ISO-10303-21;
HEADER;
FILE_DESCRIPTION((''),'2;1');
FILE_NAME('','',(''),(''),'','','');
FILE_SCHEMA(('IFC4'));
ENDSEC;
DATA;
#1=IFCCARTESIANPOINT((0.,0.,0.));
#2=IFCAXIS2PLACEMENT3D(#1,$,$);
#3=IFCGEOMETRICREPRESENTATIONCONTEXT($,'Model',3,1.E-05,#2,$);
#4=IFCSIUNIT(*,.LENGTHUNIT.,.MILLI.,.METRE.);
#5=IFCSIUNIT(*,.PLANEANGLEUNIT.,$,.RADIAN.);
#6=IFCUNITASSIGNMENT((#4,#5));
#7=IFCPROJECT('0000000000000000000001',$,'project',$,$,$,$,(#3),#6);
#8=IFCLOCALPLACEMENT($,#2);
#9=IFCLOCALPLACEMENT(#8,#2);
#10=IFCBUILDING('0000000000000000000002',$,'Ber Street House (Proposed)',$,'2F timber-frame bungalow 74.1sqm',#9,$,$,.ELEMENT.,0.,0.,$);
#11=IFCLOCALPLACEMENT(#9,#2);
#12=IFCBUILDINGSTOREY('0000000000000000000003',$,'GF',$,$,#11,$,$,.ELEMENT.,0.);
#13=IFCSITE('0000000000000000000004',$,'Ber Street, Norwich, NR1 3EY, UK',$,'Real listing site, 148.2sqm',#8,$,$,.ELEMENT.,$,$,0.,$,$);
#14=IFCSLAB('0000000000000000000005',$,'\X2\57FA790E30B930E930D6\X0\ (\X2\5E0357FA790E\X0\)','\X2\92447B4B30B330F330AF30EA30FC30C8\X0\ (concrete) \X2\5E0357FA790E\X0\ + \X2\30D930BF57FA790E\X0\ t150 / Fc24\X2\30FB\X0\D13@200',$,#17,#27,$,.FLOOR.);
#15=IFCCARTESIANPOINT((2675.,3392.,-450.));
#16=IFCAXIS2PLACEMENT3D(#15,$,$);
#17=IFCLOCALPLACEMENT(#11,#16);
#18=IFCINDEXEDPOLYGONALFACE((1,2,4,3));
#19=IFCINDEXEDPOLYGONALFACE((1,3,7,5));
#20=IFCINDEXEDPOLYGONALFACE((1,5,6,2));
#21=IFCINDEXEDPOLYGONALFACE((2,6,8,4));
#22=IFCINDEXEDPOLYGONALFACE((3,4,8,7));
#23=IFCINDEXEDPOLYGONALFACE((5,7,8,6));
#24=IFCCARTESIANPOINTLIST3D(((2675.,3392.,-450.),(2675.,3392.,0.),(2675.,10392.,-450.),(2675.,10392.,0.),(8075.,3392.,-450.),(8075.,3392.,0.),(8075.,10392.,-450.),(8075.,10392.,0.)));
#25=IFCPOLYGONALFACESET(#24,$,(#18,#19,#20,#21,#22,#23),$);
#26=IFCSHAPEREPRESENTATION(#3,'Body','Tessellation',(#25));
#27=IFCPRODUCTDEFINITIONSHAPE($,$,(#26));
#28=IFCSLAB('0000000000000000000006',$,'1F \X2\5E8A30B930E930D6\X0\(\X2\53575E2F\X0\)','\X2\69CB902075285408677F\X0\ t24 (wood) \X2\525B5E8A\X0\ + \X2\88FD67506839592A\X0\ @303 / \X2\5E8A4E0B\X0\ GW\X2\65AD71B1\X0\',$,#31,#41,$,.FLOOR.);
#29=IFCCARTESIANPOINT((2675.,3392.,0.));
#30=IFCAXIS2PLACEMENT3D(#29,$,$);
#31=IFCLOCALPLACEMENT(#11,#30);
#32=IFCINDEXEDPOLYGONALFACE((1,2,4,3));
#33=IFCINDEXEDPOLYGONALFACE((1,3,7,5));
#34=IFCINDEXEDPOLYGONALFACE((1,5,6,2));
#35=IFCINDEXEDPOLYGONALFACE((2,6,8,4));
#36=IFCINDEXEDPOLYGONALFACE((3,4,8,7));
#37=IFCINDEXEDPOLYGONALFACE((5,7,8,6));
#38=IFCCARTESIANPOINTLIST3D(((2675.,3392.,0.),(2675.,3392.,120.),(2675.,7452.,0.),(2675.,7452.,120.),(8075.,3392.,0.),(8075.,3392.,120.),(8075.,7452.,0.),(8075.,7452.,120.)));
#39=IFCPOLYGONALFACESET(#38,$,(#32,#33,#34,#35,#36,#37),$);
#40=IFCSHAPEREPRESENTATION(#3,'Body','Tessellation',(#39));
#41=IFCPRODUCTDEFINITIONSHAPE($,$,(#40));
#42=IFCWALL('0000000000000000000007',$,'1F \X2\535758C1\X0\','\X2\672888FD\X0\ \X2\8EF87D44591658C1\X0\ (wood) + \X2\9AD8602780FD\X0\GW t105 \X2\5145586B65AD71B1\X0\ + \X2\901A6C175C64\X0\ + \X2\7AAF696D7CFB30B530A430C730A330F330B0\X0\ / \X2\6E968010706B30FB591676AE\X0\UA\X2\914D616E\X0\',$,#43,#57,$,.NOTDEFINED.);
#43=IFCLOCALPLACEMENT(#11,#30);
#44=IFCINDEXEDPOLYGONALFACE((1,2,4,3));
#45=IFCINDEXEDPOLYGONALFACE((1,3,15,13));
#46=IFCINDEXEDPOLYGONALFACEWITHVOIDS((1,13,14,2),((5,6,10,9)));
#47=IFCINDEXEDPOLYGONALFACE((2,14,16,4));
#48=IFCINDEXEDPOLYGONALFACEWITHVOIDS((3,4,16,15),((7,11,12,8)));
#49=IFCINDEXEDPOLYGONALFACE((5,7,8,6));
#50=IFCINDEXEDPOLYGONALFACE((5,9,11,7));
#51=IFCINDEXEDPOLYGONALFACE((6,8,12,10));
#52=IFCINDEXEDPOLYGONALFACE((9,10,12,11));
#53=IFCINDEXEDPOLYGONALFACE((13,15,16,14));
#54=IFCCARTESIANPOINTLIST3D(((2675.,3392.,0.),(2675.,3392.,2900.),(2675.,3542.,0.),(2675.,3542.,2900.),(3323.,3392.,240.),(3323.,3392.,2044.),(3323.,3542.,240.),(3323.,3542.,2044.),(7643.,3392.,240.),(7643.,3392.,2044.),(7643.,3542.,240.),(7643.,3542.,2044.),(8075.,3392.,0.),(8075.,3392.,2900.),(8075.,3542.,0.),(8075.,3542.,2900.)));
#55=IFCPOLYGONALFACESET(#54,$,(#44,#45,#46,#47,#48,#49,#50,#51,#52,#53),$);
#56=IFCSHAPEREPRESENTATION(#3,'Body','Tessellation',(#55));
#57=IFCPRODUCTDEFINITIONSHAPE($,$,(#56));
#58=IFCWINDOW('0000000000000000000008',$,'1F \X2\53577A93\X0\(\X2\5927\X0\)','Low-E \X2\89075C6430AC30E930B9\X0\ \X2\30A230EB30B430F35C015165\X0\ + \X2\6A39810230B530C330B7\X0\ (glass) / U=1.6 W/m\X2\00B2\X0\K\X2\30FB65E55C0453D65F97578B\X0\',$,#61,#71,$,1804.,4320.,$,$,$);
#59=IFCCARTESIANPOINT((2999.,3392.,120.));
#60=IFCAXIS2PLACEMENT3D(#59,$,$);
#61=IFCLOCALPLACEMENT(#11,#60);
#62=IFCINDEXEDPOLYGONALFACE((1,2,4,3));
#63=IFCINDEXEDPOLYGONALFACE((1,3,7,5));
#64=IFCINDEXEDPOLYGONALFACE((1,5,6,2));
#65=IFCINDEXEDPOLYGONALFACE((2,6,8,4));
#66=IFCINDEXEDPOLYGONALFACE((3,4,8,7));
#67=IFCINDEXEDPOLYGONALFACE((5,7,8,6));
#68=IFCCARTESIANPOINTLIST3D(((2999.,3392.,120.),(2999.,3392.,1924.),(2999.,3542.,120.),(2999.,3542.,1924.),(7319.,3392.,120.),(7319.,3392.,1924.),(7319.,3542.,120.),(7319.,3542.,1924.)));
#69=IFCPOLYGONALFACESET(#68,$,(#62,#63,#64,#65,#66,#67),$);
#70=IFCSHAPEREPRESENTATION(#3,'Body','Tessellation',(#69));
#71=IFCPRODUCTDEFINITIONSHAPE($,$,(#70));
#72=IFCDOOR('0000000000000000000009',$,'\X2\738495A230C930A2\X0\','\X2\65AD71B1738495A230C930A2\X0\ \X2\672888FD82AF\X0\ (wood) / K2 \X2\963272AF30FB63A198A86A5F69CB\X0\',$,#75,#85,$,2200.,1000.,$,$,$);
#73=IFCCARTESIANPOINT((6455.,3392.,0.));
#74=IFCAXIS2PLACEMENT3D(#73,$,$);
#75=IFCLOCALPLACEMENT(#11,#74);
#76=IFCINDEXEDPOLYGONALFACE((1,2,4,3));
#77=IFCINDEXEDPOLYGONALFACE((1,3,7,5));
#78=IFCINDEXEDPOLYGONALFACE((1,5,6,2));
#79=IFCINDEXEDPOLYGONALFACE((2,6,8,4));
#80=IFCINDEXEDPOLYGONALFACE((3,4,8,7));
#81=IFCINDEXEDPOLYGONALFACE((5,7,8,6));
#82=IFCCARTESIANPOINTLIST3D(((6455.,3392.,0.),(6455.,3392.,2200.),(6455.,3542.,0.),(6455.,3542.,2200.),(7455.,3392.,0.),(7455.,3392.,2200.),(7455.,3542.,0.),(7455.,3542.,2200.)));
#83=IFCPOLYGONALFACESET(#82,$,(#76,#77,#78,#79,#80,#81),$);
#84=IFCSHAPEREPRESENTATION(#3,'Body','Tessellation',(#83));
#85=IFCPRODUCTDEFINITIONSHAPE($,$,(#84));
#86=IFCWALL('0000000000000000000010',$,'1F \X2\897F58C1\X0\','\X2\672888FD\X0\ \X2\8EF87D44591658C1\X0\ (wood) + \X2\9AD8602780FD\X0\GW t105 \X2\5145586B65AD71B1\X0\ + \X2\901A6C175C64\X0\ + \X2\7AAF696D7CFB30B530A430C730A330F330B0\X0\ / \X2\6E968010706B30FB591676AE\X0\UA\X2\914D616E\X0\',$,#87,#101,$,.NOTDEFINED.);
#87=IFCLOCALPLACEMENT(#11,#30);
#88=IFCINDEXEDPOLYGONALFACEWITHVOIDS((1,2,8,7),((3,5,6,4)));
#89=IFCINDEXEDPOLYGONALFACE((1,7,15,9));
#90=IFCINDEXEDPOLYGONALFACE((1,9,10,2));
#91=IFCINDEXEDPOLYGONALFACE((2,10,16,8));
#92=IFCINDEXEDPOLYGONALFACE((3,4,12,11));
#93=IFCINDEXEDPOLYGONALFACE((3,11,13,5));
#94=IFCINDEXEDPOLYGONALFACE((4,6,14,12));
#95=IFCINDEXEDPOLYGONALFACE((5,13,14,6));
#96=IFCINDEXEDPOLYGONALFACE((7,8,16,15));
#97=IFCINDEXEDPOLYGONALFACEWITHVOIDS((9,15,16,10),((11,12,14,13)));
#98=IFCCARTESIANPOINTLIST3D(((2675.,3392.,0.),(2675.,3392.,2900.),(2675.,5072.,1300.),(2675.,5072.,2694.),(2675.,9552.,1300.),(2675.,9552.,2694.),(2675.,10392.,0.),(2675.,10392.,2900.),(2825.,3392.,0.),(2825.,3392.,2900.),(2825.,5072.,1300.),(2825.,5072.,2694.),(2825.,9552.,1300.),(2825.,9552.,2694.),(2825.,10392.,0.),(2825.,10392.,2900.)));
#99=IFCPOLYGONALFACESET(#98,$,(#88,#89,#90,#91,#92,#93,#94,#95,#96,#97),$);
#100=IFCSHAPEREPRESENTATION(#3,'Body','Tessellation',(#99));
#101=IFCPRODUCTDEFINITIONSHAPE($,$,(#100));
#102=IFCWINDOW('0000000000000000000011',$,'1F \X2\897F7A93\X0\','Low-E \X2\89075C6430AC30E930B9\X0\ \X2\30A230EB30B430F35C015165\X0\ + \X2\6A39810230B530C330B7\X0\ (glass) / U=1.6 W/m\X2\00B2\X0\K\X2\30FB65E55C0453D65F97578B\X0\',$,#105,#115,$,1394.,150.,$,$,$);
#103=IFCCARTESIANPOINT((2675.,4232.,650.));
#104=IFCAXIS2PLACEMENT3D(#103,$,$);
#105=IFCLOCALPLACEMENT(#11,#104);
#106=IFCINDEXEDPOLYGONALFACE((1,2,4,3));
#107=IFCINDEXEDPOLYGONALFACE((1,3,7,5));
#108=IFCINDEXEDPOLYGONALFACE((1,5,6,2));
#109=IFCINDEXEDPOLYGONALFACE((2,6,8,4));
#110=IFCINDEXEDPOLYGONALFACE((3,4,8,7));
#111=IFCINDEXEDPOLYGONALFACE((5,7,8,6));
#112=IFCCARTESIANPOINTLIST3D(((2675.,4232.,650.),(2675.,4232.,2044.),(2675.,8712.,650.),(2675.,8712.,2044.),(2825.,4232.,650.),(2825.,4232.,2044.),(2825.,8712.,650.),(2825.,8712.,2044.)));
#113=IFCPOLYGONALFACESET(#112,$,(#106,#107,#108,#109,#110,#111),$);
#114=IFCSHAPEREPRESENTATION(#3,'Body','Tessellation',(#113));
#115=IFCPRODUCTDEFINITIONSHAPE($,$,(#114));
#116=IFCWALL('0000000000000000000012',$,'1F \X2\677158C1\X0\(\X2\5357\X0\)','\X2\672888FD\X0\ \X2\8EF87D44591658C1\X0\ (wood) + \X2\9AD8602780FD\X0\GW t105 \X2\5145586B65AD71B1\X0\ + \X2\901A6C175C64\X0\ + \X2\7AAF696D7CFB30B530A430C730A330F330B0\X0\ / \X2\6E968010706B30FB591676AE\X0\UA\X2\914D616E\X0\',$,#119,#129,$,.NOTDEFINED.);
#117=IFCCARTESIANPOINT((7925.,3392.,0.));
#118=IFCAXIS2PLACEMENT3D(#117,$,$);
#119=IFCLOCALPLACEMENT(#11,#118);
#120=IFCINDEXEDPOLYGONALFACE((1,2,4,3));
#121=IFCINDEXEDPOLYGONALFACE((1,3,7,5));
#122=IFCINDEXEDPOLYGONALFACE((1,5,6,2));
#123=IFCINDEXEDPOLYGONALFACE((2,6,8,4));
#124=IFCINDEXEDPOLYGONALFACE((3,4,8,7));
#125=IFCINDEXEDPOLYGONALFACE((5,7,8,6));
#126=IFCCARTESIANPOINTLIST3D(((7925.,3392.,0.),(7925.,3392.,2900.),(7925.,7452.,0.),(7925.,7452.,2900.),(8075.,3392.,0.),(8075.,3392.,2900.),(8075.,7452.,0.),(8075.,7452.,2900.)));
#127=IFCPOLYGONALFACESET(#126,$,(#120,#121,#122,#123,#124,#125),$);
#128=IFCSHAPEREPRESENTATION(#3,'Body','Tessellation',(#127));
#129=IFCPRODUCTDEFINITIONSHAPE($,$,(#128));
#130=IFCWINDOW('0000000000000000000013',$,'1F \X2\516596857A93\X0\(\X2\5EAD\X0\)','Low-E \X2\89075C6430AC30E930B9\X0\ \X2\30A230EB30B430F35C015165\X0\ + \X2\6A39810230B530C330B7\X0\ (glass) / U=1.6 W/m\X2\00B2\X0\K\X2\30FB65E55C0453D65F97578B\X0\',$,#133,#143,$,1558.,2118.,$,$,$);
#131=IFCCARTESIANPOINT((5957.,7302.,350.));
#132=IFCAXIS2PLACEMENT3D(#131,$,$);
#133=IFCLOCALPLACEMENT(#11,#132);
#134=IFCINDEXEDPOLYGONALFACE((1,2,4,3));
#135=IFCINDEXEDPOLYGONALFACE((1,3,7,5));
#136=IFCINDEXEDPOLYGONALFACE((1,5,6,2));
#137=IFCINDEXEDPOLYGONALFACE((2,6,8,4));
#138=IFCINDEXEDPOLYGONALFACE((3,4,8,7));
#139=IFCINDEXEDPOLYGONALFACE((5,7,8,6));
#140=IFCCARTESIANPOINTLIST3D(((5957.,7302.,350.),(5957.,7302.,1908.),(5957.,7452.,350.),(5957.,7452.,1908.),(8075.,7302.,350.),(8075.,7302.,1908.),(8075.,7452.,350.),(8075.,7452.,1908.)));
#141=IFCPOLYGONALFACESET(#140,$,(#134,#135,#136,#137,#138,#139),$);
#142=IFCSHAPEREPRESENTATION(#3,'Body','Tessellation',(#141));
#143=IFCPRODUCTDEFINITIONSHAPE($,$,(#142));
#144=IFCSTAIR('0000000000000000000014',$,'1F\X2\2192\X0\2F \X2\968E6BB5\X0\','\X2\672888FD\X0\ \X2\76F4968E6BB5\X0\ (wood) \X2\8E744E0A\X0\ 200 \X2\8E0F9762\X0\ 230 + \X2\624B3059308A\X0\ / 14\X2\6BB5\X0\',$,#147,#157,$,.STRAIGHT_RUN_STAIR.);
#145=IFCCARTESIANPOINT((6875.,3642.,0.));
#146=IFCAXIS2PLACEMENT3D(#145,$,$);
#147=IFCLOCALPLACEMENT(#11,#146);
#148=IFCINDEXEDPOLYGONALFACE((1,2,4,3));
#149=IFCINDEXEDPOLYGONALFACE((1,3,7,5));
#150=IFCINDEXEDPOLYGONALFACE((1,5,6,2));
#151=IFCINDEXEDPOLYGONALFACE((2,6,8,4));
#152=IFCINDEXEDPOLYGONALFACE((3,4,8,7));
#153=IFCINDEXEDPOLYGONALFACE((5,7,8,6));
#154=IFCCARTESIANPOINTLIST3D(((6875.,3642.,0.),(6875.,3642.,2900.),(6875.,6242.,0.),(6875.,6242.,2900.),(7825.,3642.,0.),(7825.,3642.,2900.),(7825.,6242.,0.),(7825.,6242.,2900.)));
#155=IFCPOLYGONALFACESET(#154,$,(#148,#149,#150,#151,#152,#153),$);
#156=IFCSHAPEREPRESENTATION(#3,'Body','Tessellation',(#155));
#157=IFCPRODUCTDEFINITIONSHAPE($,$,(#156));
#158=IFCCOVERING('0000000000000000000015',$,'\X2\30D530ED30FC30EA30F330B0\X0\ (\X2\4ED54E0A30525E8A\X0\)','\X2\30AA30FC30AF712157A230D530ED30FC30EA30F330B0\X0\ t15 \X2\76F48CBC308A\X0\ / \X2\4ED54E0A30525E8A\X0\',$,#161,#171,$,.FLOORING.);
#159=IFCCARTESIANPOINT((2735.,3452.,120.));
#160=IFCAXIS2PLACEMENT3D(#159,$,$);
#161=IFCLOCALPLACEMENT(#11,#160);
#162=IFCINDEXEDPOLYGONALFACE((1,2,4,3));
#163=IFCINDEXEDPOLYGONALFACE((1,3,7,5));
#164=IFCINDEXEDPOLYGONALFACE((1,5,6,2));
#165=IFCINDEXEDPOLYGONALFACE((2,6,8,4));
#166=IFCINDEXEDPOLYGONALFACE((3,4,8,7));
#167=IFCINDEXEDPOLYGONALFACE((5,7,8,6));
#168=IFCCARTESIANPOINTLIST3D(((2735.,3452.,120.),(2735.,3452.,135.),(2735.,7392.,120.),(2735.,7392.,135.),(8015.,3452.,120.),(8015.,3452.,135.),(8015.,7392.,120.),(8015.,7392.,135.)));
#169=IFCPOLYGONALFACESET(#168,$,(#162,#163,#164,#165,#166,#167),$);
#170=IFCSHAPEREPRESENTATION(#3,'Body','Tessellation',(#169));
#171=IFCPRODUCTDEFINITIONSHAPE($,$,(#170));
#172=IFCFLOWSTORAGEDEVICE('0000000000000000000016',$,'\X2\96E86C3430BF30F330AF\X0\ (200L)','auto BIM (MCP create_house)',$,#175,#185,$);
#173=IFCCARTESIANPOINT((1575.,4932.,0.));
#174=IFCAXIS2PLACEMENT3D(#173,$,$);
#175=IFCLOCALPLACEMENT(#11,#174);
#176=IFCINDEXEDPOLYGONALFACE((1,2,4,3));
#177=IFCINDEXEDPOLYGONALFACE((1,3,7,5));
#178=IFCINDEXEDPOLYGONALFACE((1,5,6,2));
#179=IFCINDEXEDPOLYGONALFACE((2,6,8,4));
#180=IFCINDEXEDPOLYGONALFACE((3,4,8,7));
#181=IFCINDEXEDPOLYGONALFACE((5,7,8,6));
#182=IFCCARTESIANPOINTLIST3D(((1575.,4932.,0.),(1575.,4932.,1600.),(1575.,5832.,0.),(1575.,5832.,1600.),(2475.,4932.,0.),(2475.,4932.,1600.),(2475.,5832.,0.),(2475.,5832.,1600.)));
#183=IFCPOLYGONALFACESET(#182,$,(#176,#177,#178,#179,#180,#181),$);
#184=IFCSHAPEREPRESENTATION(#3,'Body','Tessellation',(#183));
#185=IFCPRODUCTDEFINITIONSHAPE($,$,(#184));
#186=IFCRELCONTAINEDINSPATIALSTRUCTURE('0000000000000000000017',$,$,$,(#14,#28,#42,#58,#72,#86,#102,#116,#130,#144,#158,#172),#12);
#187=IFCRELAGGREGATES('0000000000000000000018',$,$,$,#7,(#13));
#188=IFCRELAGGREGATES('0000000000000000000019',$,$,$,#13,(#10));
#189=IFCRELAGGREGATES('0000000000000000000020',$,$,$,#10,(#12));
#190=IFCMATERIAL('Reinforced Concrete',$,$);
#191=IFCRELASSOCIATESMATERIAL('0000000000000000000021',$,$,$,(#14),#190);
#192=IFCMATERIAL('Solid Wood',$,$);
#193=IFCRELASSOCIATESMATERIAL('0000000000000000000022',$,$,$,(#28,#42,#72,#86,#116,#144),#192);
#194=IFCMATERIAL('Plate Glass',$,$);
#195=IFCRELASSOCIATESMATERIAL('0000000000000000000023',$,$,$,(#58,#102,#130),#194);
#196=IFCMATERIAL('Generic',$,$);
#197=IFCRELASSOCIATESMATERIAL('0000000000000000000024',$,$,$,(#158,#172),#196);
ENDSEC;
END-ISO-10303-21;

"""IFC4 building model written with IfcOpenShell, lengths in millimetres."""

from ifc_helpers import new_model, si_unit, frame, frame_2d, origin, place, context, project, spatial, rectangle, extrude, material, element, fill, save


model = new_model("IFC4")

# Units and contexts
model_context = context("Model", 3, precision=1e-05, world=origin())
ifc_project = project(units=[si_unit("LENGTHUNIT", "METRE", prefix="MILLI"), si_unit("PLANEANGLEUNIT", "RADIAN")], contexts=[model_context])

# Site, building, storey
site_placement = place(None, origin())
site = spatial("IfcSite", under=ifc_project, at=site_placement, Name="Ber Street, Norwich, NR1 3EY, UK", ObjectType="Real listing site, 148.2sqm", CompositionType="ELEMENT", RefElevation=0.0)
building_placement = place(site_placement, origin())
building = spatial("IfcBuilding", under=site, at=building_placement, Name="Ber Street House (Proposed)", ObjectType="2F timber-frame bungalow 74.1sqm", CompositionType="ELEMENT", ElevationOfRefHeight=0.0, ElevationOfTerrain=0.0)
storey_placement = place(building_placement, origin())
storey = spatial("IfcBuildingStorey", under=building, at=storey_placement, Name="GF", CompositionType="ELEMENT", Elevation=0.0)

# Slabs
ifc_material_1 = material(Name="Reinforced Concrete")
slab_1_placement = place(storey_placement, frame((2675.0, 3392.0, -450.0)))
element("IfcSlab", 1, at=slab_1_placement, inside=storey, material=ifc_material_1, Name="基礎スラブ (布基礎)", Description="鉄筋コンクリート (concrete) 布基礎 + ベタ基礎 t150 / Fc24・D13@200", PredefinedType="FLOOR", context=model_context, shape_type="SweptSolid", body=[
    extrude(rectangle(XDim=5400.0, YDim=7000.0, at=frame_2d((2700.0, 3500.0))), frame((2675.0, 3392.0, -450.0)), (0.0, 0.0, 1.0), 450.0),
])
ifc_material_2 = material(Name="Solid Wood")
slab_2_placement = place(storey_placement, frame((2675.0, 3392.0, 0.0)))
element("IfcSlab", 2, at=slab_2_placement, inside=storey, material=ifc_material_2, Name="1F 床スラブ(南帯)", Description="構造用合板 t24 (wood) 剛床 + 製材根太 @303 / 床下 GW断熱", PredefinedType="FLOOR", context=model_context, shape_type="SweptSolid", body=[
    extrude(rectangle(XDim=5400.0, YDim=4060.0, at=frame_2d((2700.0, 2030.0))), frame((2675.0, 3392.0, 0.0)), (0.0, 0.0, 1.0), 120.0),
])

# Wall, openings, window, door
wall_1_placement = place(storey_placement, frame((2675.0, 3392.0, 0.0)))
wall_1 = element("IfcWall", 3, at=wall_1_placement, inside=storey, material=ifc_material_2, Name="1F 南壁", Description="木製 軸組外壁 (wood) + 高性能GW t105 充填断熱 + 通気層 + 窯業系サイディング / 準耐火・外皮UA配慮", PredefinedType="NOTDEFINED", context=model_context, shape_type="SweptSolid", body=[
    extrude(rectangle(XDim=5400.0, YDim=150.0, at=frame_2d((2700.0, 75.0))), frame((2675.0, 3392.0, 0.0)), (0.0, 0.0, 1.0), 2900.0),
])
opening_1_placement = place(storey_placement, frame((2999.0, 3392.0, 120.0)))
opening_1 = element("IfcOpeningElement", 4, at=opening_1_placement, cuts=wall_1, PredefinedType="NOTDEFINED", context=model_context, shape_type="SweptSolid", body=[
    extrude(rectangle(XDim=4320.0, YDim=150.0, at=frame_2d((2160.0, 75.0))), frame((2999.0, 3392.0, 120.0)), (0.0, 0.0, 1.0), 1804.0),
])
opening_2_placement = place(storey_placement, frame((6455.0, 3392.0, 0.0)))
opening_2 = element("IfcOpeningElement", 5, at=opening_2_placement, cuts=wall_1, PredefinedType="NOTDEFINED", context=model_context, shape_type="SweptSolid", body=[
    extrude(rectangle(XDim=1000.0, YDim=150.0, at=frame_2d((500.0, 75.0))), frame((6455.0, 3392.0, 0.0)), (0.0, 0.0, 1.0), 2200.0),
])
ifc_material_3 = material(Name="Plate Glass")
window_1_placement = place(storey_placement, frame((2999.0, 3392.0, 120.0)))
window_1 = element("IfcWindow", 6, at=window_1_placement, inside=storey, material=ifc_material_3, Name="1F 南窓(大)", Description="Low-E 複層ガラス アルゴン封入 + 樹脂サッシ (glass) / U=1.6 W/m²K・日射取得型", OverallHeight=1804.0, OverallWidth=4320.0, context=model_context, shape_type="SweptSolid", body=[
    extrude(rectangle(XDim=4320.0, YDim=150.0, at=frame_2d((2160.0, 75.0))), frame((2999.0, 3392.0, 120.0)), (0.0, 0.0, 1.0), 1804.0),
])
fill(opening_1, window_1)
door_1_placement = place(storey_placement, frame((6455.0, 3392.0, 0.0)))
door_1 = element("IfcDoor", 7, at=door_1_placement, inside=storey, material=ifc_material_2, Name="玄関ドア", Description="断熱玄関ドア 木製芯 (wood) / K2 防犯・採風機構", OverallHeight=2200.0, OverallWidth=1000.0, context=model_context, shape_type="SweptSolid", body=[
    extrude(rectangle(XDim=1000.0, YDim=150.0, at=frame_2d((500.0, 75.0))), frame((6455.0, 3392.0, 0.0)), (0.0, 0.0, 1.0), 2200.0),
])
fill(opening_2, door_1)

# Walls, openings, windows
wall_2_placement = place(storey_placement, frame((2675.0, 3392.0, 0.0)))
wall_2 = element("IfcWall", 8, at=wall_2_placement, inside=storey, material=ifc_material_2, Name="1F 西壁", Description="木製 軸組外壁 (wood) + 高性能GW t105 充填断熱 + 通気層 + 窯業系サイディング / 準耐火・外皮UA配慮", PredefinedType="NOTDEFINED", context=model_context, shape_type="SweptSolid", body=[
    extrude(rectangle(XDim=150.0, YDim=7000.0, at=frame_2d((75.0, 3500.0))), frame((2675.0, 3392.0, 0.0)), (0.0, 0.0, 1.0), 2900.0),
])
opening_3_placement = place(storey_placement, frame((2675.0, 4232.0, 650.0)))
opening_3 = element("IfcOpeningElement", 9, at=opening_3_placement, cuts=wall_2, PredefinedType="NOTDEFINED", context=model_context, shape_type="SweptSolid", body=[
    extrude(rectangle(XDim=150.0, YDim=4480.0, at=frame_2d((75.0, 2240.0))), frame((2675.0, 4232.0, 650.0)), (0.0, 0.0, 1.0), 1394.0),
])
window_2_placement = place(storey_placement, frame((2675.0, 4232.0, 650.0)))
window_2 = element("IfcWindow", 10, at=window_2_placement, inside=storey, material=ifc_material_3, Name="1F 西窓", Description="Low-E 複層ガラス アルゴン封入 + 樹脂サッシ (glass) / U=1.6 W/m²K・日射取得型", OverallHeight=1394.0, OverallWidth=150.0, context=model_context, shape_type="SweptSolid", body=[
    extrude(rectangle(XDim=150.0, YDim=4480.0, at=frame_2d((75.0, 2240.0))), frame((2675.0, 4232.0, 650.0)), (0.0, 0.0, 1.0), 1394.0),
])
fill(opening_3, window_2)
wall_3_placement = place(storey_placement, frame((7925.0, 3392.0, 0.0)))
wall_3 = element("IfcWall", 11, at=wall_3_placement, inside=storey, material=ifc_material_2, Name="1F 東壁(南)", Description="木製 軸組外壁 (wood) + 高性能GW t105 充填断熱 + 通気層 + 窯業系サイディング / 準耐火・外皮UA配慮", PredefinedType="NOTDEFINED", context=model_context, shape_type="SweptSolid", body=[
    extrude(rectangle(XDim=150.0, YDim=4060.0, at=frame_2d((75.0, 2030.0))), frame((7925.0, 3392.0, 0.0)), (0.0, 0.0, 1.0), 2900.0),
])
opening_4_placement = place(storey_placement, frame((5957.0, 7302.0, 350.0)))
opening_4 = element("IfcOpeningElement", 12, at=opening_4_placement, cuts=wall_3, PredefinedType="NOTDEFINED", context=model_context, shape_type="SweptSolid", body=[
    extrude(rectangle(XDim=2118.0, YDim=150.0, at=frame_2d((1059.0, 75.0))), frame((5957.0, 7302.0, 350.0)), (0.0, 0.0, 1.0), 1558.0),
])
window_3_placement = place(storey_placement, frame((5957.0, 7302.0, 350.0)))
window_3 = element("IfcWindow", 13, at=window_3_placement, inside=storey, material=ifc_material_3, Name="1F 入隅窓(庭)", Description="Low-E 複層ガラス アルゴン封入 + 樹脂サッシ (glass) / U=1.6 W/m²K・日射取得型", OverallHeight=1558.0, OverallWidth=2118.0, context=model_context, shape_type="SweptSolid", body=[
    extrude(rectangle(XDim=2118.0, YDim=150.0, at=frame_2d((1059.0, 75.0))), frame((5957.0, 7302.0, 350.0)), (0.0, 0.0, 1.0), 1558.0),
])
fill(opening_4, window_3)

# Stair
stair_placement = place(storey_placement, frame((6875.0, 3642.0, 0.0)))
element("IfcStair", 14, at=stair_placement, inside=storey, material=ifc_material_2, Name="1F→2F 階段", Description="木製 直階段 (wood) 蹴上 200 踏面 230 + 手すり / 14段", PredefinedType="STRAIGHT_RUN_STAIR", context=model_context, shape_type="SweptSolid", body=[
    extrude(rectangle(XDim=950.0, YDim=2600.0, at=frame_2d((475.0, 1300.0))), frame((6875.0, 3642.0, 0.0)), (0.0, 0.0, 1.0), 2900.0),
])

# Covering
ifc_material_4 = material(Name="Generic")
covering_placement = place(storey_placement, frame((2735.0, 3452.0, 120.0)))
element("IfcCovering", 15, at=covering_placement, inside=storey, material=ifc_material_4, Name="フローリング (仕上げ床)", Description="オーク無垢フローリング t15 直貼り / 仕上げ床", PredefinedType="FLOORING", context=model_context, shape_type="SweptSolid", body=[
    extrude(rectangle(XDim=5280.0, YDim=3940.0, at=frame_2d((2640.0, 1970.0))), frame((2735.0, 3452.0, 120.0)), (0.0, 0.0, 1.0), 15.0),
])

# Flow storage device
flow_storage_device_placement = place(storey_placement, frame((1575.0, 4932.0, 0.0)))
element("IfcFlowStorageDevice", 16, at=flow_storage_device_placement, inside=storey, material=ifc_material_4, Name="雨水タンク (200L)", Description="auto BIM (MCP create_house)", context=model_context, shape_type="SweptSolid", body=[
    extrude(rectangle(XDim=900.0, YDim=900.0, at=frame_2d((450.0, 450.0))), frame((1575.0, 4932.0, 0.0)), (0.0, 0.0, 1.0), 1600.0),
])

save(model, "model.ifc")
